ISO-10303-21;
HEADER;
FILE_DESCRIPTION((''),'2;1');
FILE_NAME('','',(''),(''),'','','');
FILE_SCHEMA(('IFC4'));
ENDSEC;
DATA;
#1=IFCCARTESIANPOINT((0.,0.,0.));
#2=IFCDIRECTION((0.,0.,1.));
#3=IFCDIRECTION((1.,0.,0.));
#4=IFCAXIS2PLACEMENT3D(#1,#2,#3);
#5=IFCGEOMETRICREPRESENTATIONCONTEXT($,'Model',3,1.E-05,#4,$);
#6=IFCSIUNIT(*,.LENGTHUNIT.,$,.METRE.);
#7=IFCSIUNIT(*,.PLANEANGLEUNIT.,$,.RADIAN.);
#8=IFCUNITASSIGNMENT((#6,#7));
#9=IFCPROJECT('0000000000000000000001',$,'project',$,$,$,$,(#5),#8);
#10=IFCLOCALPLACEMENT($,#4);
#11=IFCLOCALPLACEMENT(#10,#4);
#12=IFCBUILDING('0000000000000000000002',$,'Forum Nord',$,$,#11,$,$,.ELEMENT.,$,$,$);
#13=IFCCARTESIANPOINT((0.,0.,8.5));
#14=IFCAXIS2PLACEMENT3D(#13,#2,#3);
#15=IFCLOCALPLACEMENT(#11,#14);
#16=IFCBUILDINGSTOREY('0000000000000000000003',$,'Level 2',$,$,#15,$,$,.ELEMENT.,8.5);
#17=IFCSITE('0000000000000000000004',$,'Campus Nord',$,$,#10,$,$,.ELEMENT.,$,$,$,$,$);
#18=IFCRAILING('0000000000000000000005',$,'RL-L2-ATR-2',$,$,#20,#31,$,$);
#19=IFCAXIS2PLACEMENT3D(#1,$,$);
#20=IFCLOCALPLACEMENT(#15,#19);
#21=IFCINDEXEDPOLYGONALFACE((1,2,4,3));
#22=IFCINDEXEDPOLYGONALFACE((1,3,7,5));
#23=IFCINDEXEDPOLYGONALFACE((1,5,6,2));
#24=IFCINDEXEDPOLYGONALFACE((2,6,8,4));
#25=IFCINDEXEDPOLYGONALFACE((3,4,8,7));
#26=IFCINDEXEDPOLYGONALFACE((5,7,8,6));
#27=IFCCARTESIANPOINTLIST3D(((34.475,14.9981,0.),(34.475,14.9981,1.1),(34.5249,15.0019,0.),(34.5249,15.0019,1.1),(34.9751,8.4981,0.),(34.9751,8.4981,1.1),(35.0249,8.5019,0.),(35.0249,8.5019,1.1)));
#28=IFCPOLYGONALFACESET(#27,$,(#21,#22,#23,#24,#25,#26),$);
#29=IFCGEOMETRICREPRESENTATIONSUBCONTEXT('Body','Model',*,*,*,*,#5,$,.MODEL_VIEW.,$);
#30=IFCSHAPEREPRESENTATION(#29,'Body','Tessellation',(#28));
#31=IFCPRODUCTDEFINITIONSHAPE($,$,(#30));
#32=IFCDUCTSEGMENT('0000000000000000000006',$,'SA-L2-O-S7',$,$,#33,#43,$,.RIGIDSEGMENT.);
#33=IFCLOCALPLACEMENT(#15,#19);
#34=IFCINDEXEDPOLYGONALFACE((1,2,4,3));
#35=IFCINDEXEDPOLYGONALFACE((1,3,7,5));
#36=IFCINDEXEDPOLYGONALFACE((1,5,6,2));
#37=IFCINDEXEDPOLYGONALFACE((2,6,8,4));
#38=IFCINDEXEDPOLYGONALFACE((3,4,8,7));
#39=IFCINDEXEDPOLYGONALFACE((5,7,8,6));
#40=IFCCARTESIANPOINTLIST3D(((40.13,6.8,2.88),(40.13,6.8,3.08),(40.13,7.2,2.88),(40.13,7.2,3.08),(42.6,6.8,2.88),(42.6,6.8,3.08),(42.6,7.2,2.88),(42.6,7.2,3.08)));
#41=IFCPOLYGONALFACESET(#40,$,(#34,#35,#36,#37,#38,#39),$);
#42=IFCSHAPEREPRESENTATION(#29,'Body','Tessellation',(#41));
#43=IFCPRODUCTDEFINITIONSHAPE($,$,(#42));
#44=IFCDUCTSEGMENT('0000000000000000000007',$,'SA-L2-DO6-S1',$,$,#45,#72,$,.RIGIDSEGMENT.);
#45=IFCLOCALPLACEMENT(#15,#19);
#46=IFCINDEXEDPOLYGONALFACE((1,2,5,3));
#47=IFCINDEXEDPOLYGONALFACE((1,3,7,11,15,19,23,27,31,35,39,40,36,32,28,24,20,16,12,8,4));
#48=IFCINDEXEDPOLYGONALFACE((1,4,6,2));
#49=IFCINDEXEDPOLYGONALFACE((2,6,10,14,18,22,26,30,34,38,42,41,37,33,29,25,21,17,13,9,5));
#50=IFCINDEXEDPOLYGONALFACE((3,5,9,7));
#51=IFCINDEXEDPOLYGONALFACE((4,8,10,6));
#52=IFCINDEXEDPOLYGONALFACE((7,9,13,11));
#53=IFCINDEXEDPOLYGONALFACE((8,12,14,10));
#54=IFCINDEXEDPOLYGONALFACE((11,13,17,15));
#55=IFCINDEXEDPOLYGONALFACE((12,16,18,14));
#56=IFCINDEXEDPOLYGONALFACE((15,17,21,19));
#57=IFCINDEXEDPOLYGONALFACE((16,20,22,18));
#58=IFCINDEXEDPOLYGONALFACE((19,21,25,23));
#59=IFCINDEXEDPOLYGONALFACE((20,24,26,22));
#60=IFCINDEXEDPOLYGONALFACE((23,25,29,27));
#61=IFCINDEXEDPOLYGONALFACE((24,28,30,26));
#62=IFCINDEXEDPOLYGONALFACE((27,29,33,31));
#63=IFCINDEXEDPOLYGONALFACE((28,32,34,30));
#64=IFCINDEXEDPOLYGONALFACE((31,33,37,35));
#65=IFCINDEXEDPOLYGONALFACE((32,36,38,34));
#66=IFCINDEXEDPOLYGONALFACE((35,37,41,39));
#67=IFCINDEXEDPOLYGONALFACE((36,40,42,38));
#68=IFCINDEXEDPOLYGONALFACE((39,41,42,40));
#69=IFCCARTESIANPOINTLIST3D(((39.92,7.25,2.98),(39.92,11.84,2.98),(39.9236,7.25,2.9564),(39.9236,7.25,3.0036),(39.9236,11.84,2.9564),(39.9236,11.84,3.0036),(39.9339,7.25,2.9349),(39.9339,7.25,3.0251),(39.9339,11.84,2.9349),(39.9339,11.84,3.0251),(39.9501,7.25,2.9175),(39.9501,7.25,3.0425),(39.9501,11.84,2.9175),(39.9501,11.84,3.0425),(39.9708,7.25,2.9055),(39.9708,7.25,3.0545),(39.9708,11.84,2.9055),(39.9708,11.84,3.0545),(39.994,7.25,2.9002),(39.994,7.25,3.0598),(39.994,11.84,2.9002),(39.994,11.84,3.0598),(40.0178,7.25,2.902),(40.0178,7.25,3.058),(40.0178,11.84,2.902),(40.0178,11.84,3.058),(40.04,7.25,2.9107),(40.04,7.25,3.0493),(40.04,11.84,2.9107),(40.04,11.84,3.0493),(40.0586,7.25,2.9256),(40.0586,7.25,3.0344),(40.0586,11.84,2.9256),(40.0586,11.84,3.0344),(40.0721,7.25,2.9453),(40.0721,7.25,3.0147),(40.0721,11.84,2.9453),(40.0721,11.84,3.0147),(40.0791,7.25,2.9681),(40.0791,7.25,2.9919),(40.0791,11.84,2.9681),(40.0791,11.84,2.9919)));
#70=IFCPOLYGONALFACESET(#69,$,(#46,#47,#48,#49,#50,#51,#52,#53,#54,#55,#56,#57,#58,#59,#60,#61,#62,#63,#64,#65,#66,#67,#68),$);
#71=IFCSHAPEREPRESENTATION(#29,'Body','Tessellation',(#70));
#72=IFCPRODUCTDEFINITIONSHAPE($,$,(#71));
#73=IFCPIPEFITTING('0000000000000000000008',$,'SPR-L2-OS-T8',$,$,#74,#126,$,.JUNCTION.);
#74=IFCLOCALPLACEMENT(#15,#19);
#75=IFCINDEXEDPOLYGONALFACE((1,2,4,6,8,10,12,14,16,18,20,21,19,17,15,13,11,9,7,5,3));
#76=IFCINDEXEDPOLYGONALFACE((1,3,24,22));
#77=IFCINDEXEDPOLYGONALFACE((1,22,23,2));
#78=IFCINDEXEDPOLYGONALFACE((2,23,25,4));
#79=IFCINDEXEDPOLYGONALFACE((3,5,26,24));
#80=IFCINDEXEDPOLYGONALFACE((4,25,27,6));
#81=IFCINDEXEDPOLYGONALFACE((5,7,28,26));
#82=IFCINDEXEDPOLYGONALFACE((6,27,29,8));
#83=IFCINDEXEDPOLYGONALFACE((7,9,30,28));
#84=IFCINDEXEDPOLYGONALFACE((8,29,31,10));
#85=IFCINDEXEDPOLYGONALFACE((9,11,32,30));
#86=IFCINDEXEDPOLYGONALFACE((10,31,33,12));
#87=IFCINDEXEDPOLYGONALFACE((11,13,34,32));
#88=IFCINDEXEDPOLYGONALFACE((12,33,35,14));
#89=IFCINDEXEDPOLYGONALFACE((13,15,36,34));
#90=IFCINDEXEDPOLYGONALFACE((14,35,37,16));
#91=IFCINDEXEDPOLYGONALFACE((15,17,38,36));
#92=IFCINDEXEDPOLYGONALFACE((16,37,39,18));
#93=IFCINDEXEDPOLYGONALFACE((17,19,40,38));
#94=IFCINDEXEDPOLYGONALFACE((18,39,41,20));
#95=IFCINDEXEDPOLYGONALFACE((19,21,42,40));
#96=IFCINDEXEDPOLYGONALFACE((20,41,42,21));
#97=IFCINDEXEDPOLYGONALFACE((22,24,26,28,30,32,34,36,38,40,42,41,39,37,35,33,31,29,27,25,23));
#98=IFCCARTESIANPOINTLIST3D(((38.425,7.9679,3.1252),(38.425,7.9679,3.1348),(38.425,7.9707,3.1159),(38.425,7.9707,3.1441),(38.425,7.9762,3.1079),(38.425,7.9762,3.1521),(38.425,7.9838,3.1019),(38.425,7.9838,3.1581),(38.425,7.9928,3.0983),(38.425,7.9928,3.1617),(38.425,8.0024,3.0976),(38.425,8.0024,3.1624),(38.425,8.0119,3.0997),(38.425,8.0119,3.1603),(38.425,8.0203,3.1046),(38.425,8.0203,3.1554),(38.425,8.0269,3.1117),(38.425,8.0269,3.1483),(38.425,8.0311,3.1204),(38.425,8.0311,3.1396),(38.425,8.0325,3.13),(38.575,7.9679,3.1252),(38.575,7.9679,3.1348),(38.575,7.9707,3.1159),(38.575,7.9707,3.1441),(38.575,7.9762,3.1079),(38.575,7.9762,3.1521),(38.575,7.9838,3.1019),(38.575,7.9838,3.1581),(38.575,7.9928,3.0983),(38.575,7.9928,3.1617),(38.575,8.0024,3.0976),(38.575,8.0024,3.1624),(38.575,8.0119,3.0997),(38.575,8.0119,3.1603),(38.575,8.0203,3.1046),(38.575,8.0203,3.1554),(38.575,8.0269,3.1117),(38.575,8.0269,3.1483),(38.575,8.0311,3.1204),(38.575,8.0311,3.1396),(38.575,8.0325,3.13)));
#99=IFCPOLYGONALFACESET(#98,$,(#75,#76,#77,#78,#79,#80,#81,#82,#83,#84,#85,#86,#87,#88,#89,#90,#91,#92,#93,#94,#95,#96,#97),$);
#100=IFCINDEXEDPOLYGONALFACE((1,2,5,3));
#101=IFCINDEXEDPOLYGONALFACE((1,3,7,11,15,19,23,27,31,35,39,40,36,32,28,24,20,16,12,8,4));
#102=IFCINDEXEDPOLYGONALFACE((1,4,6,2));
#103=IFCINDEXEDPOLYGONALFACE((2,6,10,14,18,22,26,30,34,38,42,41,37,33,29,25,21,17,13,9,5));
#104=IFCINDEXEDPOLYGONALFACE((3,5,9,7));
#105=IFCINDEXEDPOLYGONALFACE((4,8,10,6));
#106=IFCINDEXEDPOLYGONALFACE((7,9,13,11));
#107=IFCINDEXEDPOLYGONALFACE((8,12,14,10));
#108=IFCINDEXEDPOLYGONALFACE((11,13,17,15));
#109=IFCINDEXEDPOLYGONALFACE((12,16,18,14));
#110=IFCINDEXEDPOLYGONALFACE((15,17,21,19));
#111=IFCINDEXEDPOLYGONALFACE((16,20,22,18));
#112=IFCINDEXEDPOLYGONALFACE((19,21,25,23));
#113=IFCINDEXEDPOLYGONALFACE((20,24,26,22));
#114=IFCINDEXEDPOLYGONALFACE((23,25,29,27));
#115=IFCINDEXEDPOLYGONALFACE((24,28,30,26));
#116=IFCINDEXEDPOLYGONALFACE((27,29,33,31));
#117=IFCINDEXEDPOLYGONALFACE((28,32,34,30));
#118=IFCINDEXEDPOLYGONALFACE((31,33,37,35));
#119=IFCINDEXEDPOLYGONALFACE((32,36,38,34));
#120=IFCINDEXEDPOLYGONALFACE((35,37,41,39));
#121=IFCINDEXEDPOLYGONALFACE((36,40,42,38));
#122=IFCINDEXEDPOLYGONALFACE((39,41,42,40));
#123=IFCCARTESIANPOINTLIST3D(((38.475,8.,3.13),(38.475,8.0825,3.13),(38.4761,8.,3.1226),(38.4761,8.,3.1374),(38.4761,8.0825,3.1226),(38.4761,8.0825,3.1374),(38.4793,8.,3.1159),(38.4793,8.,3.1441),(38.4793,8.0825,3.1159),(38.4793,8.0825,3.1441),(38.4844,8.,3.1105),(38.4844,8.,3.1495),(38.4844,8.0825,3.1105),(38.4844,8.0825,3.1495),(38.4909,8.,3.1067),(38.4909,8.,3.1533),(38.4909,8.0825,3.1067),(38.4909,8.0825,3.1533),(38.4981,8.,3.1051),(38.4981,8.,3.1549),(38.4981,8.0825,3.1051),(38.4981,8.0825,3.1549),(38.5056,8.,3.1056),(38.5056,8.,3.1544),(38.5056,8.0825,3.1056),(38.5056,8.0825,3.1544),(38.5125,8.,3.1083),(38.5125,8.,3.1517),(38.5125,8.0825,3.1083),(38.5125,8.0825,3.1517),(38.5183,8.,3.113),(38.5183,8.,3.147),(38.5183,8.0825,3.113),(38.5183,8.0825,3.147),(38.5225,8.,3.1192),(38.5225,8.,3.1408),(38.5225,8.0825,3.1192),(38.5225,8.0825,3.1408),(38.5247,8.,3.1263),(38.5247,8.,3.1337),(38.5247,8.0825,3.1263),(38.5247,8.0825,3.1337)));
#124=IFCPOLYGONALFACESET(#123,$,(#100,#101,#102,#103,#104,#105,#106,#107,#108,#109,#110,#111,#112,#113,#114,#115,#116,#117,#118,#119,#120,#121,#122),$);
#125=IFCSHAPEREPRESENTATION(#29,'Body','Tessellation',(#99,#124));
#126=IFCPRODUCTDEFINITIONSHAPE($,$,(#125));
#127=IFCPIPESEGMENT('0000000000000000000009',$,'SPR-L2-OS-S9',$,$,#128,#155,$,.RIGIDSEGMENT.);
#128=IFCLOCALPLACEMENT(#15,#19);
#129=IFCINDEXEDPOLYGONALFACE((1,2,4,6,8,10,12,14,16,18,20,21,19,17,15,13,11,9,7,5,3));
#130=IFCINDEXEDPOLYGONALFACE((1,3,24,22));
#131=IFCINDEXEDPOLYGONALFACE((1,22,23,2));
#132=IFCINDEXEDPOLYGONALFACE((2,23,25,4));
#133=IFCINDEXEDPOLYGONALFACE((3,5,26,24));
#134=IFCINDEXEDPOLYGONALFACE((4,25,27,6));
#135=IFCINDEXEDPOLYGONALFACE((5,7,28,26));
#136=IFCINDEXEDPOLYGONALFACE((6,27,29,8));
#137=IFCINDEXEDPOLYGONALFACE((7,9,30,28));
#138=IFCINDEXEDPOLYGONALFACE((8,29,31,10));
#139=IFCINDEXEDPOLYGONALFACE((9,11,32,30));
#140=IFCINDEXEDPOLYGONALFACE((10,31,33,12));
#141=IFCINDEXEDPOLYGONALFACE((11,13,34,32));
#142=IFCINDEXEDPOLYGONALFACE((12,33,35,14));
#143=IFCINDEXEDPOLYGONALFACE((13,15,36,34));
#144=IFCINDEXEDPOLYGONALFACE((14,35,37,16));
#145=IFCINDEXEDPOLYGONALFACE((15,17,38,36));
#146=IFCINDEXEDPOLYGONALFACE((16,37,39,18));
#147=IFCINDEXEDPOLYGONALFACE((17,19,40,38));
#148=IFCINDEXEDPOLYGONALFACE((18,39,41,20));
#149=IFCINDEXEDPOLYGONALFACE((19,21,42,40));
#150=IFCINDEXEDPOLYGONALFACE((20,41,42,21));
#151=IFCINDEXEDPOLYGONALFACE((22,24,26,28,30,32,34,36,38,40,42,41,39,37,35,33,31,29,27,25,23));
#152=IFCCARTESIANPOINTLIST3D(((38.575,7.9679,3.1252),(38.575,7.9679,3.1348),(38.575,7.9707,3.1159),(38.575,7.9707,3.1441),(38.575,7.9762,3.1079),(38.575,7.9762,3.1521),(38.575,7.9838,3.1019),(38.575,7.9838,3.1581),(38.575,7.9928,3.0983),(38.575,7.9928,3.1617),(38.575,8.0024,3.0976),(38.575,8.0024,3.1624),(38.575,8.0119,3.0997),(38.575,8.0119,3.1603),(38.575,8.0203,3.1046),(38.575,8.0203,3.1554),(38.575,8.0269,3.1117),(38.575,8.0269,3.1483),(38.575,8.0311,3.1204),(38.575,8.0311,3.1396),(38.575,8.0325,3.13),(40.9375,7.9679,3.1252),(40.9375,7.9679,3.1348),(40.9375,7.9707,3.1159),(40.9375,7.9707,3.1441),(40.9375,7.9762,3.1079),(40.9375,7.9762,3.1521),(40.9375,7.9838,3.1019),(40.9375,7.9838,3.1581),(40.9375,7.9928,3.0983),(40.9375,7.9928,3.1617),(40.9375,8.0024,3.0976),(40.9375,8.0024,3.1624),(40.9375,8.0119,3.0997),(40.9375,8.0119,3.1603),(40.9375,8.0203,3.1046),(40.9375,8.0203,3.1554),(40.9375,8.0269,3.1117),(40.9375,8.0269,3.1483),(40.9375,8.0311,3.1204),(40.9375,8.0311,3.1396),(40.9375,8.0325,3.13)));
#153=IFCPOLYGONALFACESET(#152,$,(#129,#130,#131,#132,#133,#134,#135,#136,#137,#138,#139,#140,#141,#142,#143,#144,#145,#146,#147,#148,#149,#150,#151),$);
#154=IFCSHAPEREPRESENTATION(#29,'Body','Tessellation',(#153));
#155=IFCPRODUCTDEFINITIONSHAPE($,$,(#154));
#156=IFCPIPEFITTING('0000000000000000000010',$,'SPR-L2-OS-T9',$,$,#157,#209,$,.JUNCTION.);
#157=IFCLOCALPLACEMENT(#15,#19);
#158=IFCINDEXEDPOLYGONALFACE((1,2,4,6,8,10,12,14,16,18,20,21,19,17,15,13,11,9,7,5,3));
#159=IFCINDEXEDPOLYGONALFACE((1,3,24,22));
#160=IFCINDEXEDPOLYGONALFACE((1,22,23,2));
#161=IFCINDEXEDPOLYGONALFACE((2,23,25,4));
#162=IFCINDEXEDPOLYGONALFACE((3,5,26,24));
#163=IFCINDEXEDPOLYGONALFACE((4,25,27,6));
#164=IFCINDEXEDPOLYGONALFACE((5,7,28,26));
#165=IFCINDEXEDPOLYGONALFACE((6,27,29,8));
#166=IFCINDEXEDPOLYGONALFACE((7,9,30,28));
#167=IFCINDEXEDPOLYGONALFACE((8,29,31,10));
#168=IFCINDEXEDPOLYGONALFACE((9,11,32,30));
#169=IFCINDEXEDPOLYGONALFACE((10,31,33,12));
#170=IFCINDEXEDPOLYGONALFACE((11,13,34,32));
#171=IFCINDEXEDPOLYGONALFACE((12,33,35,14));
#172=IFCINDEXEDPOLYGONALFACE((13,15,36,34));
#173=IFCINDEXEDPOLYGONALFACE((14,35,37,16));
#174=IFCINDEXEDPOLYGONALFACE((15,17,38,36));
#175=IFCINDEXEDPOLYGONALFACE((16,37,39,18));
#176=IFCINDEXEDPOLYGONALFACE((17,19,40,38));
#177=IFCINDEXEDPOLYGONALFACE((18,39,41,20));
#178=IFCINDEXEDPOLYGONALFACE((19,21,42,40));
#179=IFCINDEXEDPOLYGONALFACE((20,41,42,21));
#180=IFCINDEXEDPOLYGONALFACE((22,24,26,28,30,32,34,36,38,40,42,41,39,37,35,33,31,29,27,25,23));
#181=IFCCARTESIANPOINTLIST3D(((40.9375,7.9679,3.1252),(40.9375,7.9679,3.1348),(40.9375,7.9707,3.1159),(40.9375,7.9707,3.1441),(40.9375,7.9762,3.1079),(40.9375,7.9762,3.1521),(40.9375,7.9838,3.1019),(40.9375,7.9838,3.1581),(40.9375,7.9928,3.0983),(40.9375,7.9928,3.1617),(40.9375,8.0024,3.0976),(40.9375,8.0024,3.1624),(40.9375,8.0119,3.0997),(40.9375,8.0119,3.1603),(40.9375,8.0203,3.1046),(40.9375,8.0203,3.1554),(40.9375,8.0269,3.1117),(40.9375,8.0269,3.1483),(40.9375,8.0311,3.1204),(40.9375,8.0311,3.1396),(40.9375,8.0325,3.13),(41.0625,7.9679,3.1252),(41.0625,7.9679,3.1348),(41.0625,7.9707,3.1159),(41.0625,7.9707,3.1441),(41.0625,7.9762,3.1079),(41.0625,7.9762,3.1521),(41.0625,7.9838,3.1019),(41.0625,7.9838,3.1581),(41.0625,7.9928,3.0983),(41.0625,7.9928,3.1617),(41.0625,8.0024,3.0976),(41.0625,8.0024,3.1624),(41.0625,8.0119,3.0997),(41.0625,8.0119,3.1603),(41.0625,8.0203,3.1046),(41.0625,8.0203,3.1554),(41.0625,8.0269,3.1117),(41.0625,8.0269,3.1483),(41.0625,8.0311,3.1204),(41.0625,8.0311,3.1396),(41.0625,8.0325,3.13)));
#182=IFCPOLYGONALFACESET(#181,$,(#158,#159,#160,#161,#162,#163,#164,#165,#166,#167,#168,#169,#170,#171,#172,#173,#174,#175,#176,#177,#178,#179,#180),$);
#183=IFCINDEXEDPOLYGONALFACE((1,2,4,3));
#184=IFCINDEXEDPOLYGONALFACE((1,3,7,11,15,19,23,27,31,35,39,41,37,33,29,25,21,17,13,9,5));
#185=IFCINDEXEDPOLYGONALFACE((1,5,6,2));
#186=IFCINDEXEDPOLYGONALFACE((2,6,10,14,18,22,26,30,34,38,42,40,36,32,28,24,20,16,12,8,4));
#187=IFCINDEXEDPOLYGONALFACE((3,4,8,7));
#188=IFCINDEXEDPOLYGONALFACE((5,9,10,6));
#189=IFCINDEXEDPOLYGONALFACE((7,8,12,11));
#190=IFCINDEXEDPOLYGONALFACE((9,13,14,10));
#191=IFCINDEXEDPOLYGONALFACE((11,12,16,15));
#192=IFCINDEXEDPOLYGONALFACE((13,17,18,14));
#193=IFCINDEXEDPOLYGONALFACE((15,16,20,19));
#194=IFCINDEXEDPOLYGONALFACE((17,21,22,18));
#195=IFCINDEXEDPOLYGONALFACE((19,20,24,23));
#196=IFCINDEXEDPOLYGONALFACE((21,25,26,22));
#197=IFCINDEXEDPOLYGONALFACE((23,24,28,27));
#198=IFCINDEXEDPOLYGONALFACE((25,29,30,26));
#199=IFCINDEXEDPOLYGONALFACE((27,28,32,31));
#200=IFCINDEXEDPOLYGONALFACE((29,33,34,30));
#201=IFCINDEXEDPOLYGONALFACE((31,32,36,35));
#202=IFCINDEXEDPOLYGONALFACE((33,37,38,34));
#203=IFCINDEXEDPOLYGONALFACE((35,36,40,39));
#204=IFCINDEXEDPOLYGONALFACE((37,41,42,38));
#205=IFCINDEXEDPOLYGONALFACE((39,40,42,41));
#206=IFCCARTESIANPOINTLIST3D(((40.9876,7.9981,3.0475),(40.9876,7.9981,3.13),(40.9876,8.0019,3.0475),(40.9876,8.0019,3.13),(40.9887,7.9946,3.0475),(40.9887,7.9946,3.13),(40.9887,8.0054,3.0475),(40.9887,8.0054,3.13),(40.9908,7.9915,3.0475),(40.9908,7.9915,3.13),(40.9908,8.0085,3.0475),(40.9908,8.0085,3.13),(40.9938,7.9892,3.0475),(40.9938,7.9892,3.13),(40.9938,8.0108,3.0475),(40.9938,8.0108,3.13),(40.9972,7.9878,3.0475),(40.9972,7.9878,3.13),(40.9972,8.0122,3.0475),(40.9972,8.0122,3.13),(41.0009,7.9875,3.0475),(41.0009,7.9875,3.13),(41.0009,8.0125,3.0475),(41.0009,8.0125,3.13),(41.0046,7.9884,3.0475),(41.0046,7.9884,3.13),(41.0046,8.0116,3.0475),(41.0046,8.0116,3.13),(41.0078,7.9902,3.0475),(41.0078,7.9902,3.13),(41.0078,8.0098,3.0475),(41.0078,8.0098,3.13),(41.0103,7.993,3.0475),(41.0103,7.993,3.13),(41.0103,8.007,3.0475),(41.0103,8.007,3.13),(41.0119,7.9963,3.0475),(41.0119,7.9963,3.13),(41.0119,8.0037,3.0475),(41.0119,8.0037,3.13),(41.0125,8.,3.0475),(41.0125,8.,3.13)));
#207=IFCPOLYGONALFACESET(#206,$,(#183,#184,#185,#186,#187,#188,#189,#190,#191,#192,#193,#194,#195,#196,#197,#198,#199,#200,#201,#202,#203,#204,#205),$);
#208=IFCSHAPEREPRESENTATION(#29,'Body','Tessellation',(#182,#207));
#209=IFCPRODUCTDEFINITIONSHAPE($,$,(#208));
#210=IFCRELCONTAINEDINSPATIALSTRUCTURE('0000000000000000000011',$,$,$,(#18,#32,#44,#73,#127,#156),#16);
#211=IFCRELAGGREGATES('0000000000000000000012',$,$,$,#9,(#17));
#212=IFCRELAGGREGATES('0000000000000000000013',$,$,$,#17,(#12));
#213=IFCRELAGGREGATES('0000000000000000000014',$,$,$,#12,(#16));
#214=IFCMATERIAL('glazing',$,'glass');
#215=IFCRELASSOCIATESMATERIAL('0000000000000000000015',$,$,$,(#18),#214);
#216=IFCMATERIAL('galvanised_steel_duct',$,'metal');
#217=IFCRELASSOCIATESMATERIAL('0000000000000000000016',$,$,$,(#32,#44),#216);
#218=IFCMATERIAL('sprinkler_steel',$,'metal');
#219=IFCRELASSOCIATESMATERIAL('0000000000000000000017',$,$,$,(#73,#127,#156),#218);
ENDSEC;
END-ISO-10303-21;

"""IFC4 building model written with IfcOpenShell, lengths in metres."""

from ifc_helpers import new_model, si_unit, frame, frame_2d, origin_with_axes, origin_2d_with_axis, place, context, subcontext, project, spatial, rectangle, circle, extrude, material, element, save


model = new_model("IFC4")

# Units and contexts
model_context = context("Model", 3, precision=1e-05, world=origin_with_axes())
body_context = subcontext(model_context, "Body", "Model", "MODEL_VIEW")
ifc_project = project(units=[si_unit("LENGTHUNIT", "METRE"), si_unit("PLANEANGLEUNIT", "RADIAN")], contexts=[model_context])

# Site, building, storey
site_placement = place(None, origin_with_axes())
site = spatial("IfcSite", under=ifc_project, at=site_placement, Name="Campus Nord", CompositionType="ELEMENT")
building_placement = place(site_placement, origin_with_axes())
building = spatial("IfcBuilding", under=site, at=building_placement, Name="Forum Nord", CompositionType="ELEMENT")
storey_placement = place(building_placement, frame((0.0, 0.0, 8.5), z_axis=(0.0, 0.0, 1.0), x_axis=(1.0, 0.0, 0.0)))
storey = spatial("IfcBuildingStorey", under=building, at=storey_placement, Name="Level 2", CompositionType="ELEMENT", Elevation=8.5)

# Railing
ifc_material_1 = material(Name="glazing", Category="glass")
railing_placement = place(storey_placement, frame((35.0, 8.5, 0.0), z_axis=(0.0, 0.0, 1.0), x_axis=(-0.0767, 0.99705, 0.0)))
element("IfcRailing", 1, at=railing_placement, inside=storey, material=ifc_material_1, Name="RL-L2-ATR-2", context=body_context, shape_type="SweptSolid", body=[
    extrude(rectangle(XDim=6.5192, YDim=0.05, at=frame_2d((3.2596, 0.0), x_axis=(1.0, 0.0))), origin_with_axes(), (0.0, 0.0, 1.0), 1.1),
])

# Duct segments
ifc_material_2 = material(Name="galvanised_steel_duct", Category="metal")
duct_segment_1_placement = place(storey_placement, frame((40.13, 7.0, 2.98), z_axis=(1.0, 0.0, 0.0), x_axis=(0.0, 1.0, 0.0)))
element("IfcDuctSegment", 2, at=duct_segment_1_placement, inside=storey, material=ifc_material_2, Name="SA-L2-O-S7", PredefinedType="RIGIDSEGMENT", context=body_context, shape_type="SweptSolid", body=[
    extrude(rectangle(XDim=0.4, YDim=0.2, at=origin_2d_with_axis()), origin_with_axes(), (0.0, 0.0, 1.0), 2.47),
])
duct_segment_2_placement = place(storey_placement, frame((40.0, 7.25, 2.98), z_axis=(0.0, 1.0, 0.0), x_axis=(-1.0, 0.0, 0.0)))
element("IfcDuctSegment", 3, at=duct_segment_2_placement, inside=storey, material=ifc_material_2, Name="SA-L2-DO6-S1", PredefinedType="RIGIDSEGMENT", context=body_context, shape_type="SweptSolid", body=[
    extrude(circle(Radius=0.08, at=origin_2d_with_axis()), origin_with_axes(), (0.0, 0.0, 1.0), 4.59),
])

# Pipe fitting
ifc_material_3 = material(Name="sprinkler_steel", Category="metal")
pipe_fitting_1_placement = place(storey_placement, frame((38.425, 8.0, 3.13), z_axis=(1.0, 0.0, 0.0), x_axis=(0.0, 1.0, 0.0)))
element("IfcPipeFitting", 4, at=pipe_fitting_1_placement, inside=storey, material=ifc_material_3, Name="SPR-L2-OS-T8", PredefinedType="JUNCTION", context=body_context, shape_type="SweptSolid", body=[
    extrude(circle(Radius=0.0325, at=origin_2d_with_axis()), origin_with_axes(), (0.0, 0.0, 1.0), 0.15),
    extrude(circle(Radius=0.025, at=origin_2d_with_axis()), frame((0.0, 0.0, 0.075), z_axis=(1.0, 0.0, 0.0), x_axis=(0.0, 0.0, -1.0)), (0.0, 0.0, 1.0), 0.0825),
])

# Pipe segment
pipe_segment_1_placement = place(storey_placement, frame((38.575, 8.0, 3.13), z_axis=(1.0, 0.0, 0.0), x_axis=(0.0, 1.0, 0.0)))
element("IfcPipeSegment", 5, at=pipe_segment_1_placement, inside=storey, material=ifc_material_3, Name="SPR-L2-OS-S9", PredefinedType="RIGIDSEGMENT", context=body_context, shape_type="SweptSolid", body=[
    extrude(circle(Radius=0.0325, at=origin_2d_with_axis()), origin_with_axes(), (0.0, 0.0, 1.0), 2.3625),
])

# Pipe fitting
pipe_fitting_2_placement = place(storey_placement, frame((40.9375, 8.0, 3.13), z_axis=(1.0, 0.0, 0.0), x_axis=(0.0, 1.0, 0.0)))
element("IfcPipeFitting", 6, at=pipe_fitting_2_placement, inside=storey, material=ifc_material_3, Name="SPR-L2-OS-T9", PredefinedType="JUNCTION", context=body_context, shape_type="SweptSolid", body=[
    extrude(circle(Radius=0.0325, at=origin_2d_with_axis()), origin_with_axes(), (0.0, 0.0, 1.0), 0.125),
    extrude(circle(Radius=0.0125, at=origin_2d_with_axis()), frame((0.0, 0.0, 0.0625), z_axis=(0.0, -1.0, 0.0), x_axis=(0.0, 0.0, 1.0)), (0.0, 0.0, 1.0), 0.0825),
])

save(model, "model.ifc")
